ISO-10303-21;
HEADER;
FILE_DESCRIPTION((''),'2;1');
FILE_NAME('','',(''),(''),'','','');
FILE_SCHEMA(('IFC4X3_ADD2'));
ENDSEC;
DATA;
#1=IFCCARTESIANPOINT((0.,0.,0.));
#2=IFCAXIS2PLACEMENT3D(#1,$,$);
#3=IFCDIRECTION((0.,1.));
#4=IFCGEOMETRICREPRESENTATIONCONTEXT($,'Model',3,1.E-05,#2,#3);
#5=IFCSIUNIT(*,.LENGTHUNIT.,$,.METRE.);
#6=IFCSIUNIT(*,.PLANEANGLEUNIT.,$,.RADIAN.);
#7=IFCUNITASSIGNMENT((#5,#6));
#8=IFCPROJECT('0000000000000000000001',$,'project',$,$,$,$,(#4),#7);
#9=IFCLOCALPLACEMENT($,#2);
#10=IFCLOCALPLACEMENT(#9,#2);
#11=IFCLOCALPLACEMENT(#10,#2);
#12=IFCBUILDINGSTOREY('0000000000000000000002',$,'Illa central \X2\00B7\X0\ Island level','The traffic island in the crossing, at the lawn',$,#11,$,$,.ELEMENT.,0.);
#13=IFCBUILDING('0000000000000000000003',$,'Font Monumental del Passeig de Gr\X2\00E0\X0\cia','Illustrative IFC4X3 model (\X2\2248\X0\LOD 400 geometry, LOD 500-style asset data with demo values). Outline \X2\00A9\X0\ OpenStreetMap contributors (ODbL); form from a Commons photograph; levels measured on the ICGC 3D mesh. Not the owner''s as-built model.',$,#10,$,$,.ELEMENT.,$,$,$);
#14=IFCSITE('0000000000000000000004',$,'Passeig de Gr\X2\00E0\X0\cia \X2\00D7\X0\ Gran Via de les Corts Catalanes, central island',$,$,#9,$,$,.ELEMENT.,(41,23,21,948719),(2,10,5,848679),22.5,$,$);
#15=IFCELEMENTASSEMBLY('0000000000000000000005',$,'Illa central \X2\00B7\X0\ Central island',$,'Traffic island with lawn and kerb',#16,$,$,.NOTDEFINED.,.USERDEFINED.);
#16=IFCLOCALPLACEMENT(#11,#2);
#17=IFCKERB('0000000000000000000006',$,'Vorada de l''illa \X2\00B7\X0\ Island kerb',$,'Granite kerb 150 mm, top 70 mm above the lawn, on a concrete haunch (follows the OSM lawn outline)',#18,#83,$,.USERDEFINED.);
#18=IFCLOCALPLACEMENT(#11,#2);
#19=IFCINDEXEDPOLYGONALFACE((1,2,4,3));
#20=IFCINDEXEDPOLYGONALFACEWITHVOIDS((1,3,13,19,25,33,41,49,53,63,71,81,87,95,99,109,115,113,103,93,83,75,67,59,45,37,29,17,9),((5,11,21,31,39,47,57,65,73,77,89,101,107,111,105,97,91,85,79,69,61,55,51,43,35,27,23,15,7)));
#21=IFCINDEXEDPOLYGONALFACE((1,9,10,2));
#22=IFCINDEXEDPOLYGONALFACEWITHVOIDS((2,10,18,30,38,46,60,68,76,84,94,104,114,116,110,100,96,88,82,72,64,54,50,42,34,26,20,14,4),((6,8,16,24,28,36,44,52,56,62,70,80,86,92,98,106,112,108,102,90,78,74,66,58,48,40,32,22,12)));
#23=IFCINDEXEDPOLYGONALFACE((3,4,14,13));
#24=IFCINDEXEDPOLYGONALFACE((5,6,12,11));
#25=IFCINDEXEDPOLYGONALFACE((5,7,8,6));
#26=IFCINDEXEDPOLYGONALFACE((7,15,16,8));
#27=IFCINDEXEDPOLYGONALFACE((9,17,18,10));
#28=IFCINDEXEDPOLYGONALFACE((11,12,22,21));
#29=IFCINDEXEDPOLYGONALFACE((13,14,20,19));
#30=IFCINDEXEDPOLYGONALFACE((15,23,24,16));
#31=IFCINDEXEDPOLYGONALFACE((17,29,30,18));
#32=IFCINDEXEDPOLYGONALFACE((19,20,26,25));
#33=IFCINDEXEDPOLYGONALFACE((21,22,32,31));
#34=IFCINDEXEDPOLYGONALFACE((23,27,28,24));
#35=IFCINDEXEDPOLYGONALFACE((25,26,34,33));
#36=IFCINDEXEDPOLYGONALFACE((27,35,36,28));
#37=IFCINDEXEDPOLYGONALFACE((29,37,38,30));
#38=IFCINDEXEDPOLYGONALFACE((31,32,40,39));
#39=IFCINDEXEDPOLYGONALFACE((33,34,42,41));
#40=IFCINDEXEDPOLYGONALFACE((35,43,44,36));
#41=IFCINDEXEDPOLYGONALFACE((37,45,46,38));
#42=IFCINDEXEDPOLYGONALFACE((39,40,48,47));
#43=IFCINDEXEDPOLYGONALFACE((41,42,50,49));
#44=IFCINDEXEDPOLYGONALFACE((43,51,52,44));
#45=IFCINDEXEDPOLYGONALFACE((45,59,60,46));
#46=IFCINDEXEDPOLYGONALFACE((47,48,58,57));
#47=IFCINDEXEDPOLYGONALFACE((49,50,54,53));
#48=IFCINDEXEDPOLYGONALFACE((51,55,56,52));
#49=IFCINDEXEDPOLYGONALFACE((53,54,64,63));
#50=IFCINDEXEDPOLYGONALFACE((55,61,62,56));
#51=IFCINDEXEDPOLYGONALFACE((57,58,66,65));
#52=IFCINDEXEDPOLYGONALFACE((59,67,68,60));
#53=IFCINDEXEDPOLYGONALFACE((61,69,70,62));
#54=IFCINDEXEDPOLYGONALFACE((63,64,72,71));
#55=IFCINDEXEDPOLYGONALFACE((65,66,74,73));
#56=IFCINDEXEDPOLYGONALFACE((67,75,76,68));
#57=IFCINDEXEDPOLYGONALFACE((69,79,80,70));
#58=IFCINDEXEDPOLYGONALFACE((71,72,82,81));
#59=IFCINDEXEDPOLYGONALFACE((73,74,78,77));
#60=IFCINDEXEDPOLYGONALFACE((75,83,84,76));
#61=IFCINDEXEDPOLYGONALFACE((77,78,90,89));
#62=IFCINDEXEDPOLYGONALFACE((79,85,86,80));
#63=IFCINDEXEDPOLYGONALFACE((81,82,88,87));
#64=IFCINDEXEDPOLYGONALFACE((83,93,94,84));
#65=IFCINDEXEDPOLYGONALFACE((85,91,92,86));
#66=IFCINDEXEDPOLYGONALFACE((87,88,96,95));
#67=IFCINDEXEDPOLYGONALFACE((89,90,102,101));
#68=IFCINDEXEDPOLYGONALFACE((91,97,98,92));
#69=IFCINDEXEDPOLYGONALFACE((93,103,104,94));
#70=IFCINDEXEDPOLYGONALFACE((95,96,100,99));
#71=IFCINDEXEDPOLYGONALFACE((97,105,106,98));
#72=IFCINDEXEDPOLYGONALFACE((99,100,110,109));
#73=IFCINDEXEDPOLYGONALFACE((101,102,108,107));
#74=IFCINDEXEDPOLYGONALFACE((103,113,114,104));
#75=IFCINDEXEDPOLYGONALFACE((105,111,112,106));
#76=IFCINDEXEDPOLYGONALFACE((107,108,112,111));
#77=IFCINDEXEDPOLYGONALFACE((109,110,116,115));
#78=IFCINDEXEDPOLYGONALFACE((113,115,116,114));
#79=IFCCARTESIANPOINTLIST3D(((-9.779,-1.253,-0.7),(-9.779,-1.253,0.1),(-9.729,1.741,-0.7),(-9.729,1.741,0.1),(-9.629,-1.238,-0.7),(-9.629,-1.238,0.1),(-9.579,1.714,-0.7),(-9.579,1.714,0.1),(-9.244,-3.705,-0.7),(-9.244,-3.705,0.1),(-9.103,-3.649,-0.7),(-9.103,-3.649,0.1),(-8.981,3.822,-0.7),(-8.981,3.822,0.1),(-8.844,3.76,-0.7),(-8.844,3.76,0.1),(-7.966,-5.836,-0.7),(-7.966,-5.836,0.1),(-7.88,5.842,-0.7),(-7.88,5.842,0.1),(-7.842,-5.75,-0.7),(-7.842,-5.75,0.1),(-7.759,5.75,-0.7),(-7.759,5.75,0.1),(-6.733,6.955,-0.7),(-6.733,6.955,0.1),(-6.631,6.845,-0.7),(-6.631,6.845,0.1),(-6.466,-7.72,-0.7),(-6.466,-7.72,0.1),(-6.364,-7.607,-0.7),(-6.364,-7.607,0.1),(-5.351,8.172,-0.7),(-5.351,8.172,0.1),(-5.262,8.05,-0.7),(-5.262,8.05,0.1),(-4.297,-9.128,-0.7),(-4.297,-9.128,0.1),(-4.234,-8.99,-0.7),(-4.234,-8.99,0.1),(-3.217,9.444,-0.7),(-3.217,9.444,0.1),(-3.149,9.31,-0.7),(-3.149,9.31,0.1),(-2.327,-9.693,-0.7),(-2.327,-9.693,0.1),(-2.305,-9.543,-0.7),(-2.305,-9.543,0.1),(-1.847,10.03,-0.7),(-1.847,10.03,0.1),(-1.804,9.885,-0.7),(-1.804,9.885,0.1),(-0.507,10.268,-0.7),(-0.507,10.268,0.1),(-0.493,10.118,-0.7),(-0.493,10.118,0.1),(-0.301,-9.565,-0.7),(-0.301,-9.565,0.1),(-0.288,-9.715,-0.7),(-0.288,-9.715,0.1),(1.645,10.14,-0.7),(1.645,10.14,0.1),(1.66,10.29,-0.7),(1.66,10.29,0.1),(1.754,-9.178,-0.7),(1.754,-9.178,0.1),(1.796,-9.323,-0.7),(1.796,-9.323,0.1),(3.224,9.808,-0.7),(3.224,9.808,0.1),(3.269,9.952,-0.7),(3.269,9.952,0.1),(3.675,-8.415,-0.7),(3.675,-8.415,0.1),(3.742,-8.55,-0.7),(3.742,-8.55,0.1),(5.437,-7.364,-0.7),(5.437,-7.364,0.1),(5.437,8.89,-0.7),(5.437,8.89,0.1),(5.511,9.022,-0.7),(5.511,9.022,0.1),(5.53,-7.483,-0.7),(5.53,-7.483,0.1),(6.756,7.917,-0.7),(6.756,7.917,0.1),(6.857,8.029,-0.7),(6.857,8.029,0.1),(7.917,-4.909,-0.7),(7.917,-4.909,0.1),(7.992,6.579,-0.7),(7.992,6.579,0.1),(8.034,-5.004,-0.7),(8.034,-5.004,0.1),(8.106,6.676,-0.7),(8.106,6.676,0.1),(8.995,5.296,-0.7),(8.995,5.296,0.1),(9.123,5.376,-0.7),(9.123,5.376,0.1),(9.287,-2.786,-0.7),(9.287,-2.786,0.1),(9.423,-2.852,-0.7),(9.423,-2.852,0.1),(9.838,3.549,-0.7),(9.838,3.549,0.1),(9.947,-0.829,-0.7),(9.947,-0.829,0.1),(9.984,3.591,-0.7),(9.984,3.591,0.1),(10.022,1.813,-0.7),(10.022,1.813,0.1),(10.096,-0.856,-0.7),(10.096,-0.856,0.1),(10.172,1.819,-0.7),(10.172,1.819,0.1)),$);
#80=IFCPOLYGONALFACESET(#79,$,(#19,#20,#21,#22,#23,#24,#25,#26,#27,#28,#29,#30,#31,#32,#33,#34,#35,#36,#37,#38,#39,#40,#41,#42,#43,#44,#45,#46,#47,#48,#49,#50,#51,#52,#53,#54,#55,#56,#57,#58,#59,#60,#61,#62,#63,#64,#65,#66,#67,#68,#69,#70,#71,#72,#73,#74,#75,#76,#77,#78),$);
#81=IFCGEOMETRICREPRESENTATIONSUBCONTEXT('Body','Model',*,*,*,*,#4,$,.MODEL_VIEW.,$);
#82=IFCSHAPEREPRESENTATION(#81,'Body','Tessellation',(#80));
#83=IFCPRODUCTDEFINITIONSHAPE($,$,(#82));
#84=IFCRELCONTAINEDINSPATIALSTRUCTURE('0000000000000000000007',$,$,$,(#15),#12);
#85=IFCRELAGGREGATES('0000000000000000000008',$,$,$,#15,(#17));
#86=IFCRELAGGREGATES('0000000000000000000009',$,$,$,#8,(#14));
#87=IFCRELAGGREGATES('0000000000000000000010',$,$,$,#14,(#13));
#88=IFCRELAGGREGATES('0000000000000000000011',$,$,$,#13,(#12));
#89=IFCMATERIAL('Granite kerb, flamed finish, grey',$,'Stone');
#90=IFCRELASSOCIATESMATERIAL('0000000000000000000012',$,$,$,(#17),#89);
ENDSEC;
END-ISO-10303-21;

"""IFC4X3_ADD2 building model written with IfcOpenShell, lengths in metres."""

from ifc_helpers import new_model, si_unit, direction, frame, origin, place, context, subcontext, project, spatial, polyline, outline, extrude, material, element, aggregate, save


model = new_model("IFC4X3_ADD2")

# Units and contexts
model_context = context("Model", 3, precision=1e-05, world=origin(), true_north=direction((0.0, 1.0)))
body_context = subcontext(model_context, "Body", "Model", "MODEL_VIEW")
ifc_project = project(units=[si_unit("LENGTHUNIT", "METRE"), si_unit("PLANEANGLEUNIT", "RADIAN")], contexts=[model_context])

# Site, building, storey
site_placement = place(None, origin())
site = spatial("IfcSite", under=ifc_project, at=site_placement, Name="Passeig de Gràcia × Gran Via de les Corts Catalanes, central island", CompositionType="ELEMENT", RefLatitude=(41, 23, 21, 948719), RefLongitude=(2, 10, 5, 848679), RefElevation=22.5)
building_placement = place(site_placement, origin())
building = spatial("IfcBuilding", under=site, at=building_placement, Name="Font Monumental del Passeig de Gràcia", Description="Illustrative IFC4X3 model (≈LOD 400 geometry, LOD 500-style asset data with demo values). Outline © OpenStreetMap contributors (ODbL); form from a Commons photograph; levels measured on the ICGC 3D mesh. Not the owner's as-built model.", CompositionType="ELEMENT")
storey_placement = place(building_placement, origin())
storey = spatial("IfcBuildingStorey", under=building, at=storey_placement, Name="Illa central · Island level", Description="The traffic island in the crossing, at the lawn", CompositionType="ELEMENT", Elevation=0.0)

# Element assembly
assembly_1_placement = place(building_placement, origin())
assembly_1 = element("IfcElementAssembly", 1, at=assembly_1_placement, inside=storey, Name="Illa central · Central island", ObjectType="Traffic island with lawn and kerb", AssemblyPlace="NOTDEFINED", PredefinedType="USERDEFINED")

# Kerb
ifc_material_1 = material(Name="Granite kerb, flamed finish, grey", Category="Stone")
kerb_placement = place(building_placement, origin())
kerb = element("IfcKerb", 2, at=kerb_placement, material=ifc_material_1, Name="Vorada de l'illa · Island kerb", ObjectType="Granite kerb 150 mm, top 70 mm above the lawn, on a concrete haunch (follows the OSM lawn outline)", PredefinedType="USERDEFINED", context=body_context, shape_type="SweptSolid", body=[
    extrude(outline(polyline([(-1.847, 10.03), (-3.217, 9.444), (-5.351, 8.172), (-6.733, 6.955), (-7.88, 5.842), (-8.981, 3.822), (-9.729, 1.741), (-9.779, -1.253), (-9.244, -3.705), (-7.966, -5.836), (-6.466, -7.72), (-4.297, -9.128), (-2.327, -9.693), (-0.288, -9.715), (1.796, -9.323), (3.742, -8.55), (5.53, -7.483), (8.034, -5.004), (9.423, -2.852), (10.096, -0.856), (10.172, 1.819), (9.984, 3.591), (9.123, 5.376), (8.106, 6.676), (6.857, 8.029), (5.511, 9.022), (3.269, 9.952), (1.66, 10.29), (-0.507, 10.268), (-1.847, 10.03)]), holes=[polyline([(-1.804, 9.885), (-3.149, 9.31), (-5.262, 8.05), (-6.631, 6.845), (-7.759, 5.75), (-8.844, 3.76), (-9.579, 1.714), (-9.629, -1.238), (-9.103, -3.649), (-7.842, -5.75), (-6.364, -7.607), (-4.234, -8.99), (-2.305, -9.543), (-0.301, -9.565), (1.754, -9.178), (3.675, -8.415), (5.437, -7.364), (7.917, -4.909), (9.287, -2.786), (9.947, -0.829), (10.022, 1.813), (9.838, 3.549), (8.995, 5.296), (7.992, 6.579), (6.756, 7.917), (5.437, 8.89), (3.224, 9.808), (1.645, 10.14), (-0.493, 10.118), (-1.804, 9.885)])]), frame((0.0, 0.0, -0.7)), (0.0, 0.0, 1.0), 0.8),
])
aggregate(assembly_1, [kerb])

save(model, "model.ifc")
